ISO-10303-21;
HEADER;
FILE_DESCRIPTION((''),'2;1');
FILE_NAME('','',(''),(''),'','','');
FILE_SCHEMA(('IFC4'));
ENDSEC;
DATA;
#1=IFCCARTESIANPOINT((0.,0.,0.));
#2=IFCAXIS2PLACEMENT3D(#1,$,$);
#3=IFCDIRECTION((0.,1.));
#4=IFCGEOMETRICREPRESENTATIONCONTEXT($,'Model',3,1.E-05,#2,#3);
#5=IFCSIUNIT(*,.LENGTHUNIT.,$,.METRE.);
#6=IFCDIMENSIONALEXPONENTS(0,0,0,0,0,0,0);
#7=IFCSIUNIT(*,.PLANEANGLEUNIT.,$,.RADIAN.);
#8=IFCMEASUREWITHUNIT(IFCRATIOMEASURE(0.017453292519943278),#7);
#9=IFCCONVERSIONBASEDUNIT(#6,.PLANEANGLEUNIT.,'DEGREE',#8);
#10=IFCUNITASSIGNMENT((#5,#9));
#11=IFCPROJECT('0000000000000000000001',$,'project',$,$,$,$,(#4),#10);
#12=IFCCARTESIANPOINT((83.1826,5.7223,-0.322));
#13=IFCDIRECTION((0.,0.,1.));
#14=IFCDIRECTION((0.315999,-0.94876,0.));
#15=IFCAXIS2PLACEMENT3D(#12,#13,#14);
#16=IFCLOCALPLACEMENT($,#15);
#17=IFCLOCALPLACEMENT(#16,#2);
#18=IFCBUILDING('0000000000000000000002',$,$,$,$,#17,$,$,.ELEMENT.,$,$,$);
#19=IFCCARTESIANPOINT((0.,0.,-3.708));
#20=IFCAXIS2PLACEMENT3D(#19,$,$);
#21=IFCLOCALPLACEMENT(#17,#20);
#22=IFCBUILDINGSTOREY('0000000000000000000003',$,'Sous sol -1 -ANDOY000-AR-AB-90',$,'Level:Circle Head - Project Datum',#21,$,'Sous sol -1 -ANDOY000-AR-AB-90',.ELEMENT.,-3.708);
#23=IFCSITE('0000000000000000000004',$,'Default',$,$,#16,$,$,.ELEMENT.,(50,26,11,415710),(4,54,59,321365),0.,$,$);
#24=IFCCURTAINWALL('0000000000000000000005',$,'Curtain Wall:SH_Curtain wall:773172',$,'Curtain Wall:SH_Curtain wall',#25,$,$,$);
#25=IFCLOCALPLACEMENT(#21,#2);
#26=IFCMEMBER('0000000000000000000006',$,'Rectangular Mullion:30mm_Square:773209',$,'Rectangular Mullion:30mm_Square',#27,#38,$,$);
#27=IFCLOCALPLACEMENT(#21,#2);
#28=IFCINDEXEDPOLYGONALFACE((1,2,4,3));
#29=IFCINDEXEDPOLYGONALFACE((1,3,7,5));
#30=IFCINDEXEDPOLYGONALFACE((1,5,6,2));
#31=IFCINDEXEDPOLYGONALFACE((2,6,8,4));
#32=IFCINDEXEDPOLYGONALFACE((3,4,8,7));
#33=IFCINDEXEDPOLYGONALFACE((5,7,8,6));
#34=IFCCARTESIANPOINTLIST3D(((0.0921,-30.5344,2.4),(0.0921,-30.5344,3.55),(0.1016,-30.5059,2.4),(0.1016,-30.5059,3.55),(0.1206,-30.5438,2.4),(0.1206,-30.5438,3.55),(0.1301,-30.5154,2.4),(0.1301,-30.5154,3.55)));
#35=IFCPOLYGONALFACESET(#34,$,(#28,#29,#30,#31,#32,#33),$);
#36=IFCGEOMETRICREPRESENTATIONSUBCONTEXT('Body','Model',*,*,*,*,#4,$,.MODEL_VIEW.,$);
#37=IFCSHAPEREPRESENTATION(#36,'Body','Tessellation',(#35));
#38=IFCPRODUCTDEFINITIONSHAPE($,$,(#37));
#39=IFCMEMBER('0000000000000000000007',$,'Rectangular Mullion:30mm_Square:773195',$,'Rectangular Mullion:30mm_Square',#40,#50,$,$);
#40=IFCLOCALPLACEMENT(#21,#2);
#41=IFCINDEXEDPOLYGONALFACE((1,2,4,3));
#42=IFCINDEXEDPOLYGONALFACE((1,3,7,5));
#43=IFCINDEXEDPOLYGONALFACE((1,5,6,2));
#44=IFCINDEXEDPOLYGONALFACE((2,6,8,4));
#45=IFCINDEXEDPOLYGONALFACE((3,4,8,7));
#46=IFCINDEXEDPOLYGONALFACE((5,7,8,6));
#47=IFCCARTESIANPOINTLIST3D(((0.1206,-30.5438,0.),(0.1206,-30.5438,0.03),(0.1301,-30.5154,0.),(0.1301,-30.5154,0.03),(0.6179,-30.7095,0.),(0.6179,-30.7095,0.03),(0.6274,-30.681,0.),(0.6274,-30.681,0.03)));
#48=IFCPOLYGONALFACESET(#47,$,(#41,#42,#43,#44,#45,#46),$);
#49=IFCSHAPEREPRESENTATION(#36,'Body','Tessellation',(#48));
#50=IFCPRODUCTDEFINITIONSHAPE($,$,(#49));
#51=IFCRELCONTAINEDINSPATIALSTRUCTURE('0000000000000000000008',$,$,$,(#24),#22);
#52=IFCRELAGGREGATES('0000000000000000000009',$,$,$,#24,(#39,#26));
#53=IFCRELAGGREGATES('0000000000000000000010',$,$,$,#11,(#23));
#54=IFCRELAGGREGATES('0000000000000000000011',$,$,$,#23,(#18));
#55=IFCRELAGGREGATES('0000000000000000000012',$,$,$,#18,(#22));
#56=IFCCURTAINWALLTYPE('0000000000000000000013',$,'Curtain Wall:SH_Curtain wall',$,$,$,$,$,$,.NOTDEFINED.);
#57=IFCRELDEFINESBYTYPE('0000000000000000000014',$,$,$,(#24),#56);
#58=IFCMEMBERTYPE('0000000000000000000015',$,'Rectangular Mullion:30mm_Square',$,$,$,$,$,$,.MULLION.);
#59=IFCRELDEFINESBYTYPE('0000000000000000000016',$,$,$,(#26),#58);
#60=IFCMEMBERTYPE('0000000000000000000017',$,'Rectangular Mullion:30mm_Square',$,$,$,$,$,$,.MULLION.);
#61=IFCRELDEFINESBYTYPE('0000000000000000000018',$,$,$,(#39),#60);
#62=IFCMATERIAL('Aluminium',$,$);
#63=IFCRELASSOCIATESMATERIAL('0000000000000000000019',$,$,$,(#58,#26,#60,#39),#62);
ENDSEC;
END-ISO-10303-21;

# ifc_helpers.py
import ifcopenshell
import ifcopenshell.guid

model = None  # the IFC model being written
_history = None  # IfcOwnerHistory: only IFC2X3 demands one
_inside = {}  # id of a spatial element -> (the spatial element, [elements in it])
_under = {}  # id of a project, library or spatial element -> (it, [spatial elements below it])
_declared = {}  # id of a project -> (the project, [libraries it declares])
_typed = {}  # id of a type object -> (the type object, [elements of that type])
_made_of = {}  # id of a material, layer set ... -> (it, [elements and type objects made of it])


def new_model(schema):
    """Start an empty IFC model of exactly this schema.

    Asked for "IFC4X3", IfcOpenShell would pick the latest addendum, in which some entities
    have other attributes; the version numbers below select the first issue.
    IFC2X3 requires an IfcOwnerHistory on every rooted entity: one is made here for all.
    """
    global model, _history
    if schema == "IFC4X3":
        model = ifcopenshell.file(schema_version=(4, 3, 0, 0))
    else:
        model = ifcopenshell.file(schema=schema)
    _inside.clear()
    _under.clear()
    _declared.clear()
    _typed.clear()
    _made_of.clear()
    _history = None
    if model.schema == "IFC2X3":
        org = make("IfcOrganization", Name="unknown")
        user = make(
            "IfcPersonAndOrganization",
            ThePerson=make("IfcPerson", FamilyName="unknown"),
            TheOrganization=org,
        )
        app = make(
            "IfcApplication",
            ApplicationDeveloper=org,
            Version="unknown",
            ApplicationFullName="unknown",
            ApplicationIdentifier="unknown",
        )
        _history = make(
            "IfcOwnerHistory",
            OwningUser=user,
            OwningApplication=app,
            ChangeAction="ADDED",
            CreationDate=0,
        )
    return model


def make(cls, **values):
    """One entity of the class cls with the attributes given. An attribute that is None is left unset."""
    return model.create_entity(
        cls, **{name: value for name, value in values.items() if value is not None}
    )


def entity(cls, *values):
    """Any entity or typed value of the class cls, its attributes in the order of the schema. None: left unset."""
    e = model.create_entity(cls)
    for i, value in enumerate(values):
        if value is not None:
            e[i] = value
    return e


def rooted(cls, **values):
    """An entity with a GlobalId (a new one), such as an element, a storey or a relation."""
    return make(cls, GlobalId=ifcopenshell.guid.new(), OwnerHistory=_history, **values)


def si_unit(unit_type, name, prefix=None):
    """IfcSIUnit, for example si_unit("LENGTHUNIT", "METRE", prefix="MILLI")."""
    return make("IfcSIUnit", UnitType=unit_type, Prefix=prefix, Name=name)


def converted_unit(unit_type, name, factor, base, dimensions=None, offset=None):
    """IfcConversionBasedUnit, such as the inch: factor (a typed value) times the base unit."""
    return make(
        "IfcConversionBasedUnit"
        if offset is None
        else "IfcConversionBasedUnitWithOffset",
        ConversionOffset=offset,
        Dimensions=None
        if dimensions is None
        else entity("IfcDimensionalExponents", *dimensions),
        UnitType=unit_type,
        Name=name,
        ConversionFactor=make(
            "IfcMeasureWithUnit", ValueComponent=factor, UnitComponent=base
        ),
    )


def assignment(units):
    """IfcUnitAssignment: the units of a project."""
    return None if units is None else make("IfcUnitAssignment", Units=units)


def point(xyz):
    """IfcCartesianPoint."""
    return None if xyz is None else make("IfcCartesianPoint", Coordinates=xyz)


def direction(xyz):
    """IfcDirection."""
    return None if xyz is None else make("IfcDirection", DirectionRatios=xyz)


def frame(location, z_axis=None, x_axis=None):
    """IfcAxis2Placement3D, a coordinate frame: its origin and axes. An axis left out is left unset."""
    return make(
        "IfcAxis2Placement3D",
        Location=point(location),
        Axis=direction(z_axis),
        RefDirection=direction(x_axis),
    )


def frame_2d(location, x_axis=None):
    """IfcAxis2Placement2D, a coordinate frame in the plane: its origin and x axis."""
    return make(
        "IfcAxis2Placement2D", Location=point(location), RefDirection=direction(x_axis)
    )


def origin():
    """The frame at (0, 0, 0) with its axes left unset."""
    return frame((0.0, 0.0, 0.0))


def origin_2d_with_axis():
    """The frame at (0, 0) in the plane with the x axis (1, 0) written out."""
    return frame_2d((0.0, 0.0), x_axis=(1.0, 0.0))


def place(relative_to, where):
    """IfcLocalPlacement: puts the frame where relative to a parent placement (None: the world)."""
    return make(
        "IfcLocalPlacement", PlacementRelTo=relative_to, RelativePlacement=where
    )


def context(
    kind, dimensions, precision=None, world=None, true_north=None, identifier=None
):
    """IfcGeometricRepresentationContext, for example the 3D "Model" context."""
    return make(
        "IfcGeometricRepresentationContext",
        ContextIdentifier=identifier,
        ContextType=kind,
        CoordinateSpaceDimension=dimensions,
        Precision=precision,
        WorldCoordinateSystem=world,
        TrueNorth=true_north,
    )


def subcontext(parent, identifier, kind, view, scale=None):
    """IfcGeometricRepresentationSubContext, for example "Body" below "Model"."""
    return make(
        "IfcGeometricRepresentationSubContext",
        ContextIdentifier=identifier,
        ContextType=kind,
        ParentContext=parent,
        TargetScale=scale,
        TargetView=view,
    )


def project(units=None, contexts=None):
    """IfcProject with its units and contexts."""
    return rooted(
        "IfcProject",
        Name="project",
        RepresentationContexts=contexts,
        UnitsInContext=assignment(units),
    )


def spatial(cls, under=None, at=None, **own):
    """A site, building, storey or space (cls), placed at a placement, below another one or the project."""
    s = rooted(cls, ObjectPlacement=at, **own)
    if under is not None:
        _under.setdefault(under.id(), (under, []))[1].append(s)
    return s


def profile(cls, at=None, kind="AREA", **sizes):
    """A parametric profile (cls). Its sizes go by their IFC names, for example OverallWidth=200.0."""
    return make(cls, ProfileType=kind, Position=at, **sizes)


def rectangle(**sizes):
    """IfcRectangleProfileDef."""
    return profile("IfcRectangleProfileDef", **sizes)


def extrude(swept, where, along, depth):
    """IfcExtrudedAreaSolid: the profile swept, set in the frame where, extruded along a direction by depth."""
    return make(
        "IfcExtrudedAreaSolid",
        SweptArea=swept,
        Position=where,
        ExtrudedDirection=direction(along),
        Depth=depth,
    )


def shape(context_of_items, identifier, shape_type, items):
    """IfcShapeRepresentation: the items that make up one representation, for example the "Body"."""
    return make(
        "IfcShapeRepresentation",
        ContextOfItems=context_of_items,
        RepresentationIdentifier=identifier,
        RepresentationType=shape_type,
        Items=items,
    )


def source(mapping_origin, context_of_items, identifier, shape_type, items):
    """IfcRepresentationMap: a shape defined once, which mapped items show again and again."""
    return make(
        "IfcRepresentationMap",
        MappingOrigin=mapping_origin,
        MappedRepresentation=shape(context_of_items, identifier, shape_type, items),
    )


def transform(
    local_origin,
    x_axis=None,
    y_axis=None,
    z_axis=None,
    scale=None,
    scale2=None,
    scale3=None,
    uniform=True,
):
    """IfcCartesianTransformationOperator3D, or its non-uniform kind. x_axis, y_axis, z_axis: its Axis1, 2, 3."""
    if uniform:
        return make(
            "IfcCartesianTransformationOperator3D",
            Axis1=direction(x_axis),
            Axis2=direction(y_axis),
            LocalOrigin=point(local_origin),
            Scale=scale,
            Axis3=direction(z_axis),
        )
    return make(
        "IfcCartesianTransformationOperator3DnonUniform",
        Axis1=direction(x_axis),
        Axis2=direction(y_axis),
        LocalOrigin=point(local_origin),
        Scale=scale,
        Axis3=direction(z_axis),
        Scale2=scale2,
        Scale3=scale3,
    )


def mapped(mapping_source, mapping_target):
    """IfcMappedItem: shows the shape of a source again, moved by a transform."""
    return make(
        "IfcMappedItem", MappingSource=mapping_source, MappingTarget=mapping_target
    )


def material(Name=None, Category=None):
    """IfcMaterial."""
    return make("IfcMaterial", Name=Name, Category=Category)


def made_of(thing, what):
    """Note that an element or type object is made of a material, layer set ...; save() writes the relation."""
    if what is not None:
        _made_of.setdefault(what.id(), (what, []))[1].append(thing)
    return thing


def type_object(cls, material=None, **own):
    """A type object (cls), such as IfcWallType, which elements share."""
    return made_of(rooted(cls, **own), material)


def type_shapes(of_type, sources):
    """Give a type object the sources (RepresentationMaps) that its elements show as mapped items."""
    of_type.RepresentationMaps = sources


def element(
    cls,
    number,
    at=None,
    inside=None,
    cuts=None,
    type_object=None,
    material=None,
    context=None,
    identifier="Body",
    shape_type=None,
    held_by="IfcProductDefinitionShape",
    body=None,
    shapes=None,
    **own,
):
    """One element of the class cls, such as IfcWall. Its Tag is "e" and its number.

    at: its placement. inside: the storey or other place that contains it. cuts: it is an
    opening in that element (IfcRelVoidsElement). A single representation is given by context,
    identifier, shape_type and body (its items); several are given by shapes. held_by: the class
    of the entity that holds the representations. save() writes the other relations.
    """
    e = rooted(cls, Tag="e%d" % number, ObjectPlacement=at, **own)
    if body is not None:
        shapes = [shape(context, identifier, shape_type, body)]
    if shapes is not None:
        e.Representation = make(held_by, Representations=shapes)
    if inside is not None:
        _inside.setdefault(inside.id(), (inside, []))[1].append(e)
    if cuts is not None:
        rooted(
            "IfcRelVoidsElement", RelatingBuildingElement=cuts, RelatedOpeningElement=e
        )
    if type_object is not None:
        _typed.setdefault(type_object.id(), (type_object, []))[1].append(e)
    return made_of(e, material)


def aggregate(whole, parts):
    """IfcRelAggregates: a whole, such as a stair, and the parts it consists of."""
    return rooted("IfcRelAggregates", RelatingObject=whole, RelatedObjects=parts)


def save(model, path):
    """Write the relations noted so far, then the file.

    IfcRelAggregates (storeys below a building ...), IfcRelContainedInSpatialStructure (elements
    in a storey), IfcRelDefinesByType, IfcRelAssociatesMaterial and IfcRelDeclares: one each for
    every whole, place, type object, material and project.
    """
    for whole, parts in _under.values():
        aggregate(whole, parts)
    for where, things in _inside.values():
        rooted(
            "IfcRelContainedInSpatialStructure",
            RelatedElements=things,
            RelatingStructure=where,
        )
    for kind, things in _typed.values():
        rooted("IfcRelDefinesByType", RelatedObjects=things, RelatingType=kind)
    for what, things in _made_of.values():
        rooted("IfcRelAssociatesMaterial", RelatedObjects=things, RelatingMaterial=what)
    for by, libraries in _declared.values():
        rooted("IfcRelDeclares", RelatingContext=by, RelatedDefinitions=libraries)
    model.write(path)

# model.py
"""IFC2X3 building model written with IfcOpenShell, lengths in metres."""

from ifc_helpers import new_model, entity, si_unit, converted_unit, direction, frame, origin, origin_2d_with_axis, place, context, subcontext, project, spatial, rectangle, extrude, source, transform, mapped, material, type_object, type_shapes, element, aggregate, save


model = new_model("IFC2X3")

# Units and contexts
model_context = context("Model", 3, precision=1e-05, world=origin(), true_north=direction((0.0, 1.0)))
body_context = subcontext(model_context, "Body", "Model", "MODEL_VIEW")
ifc_project = project(units=[si_unit("LENGTHUNIT", "METRE"), converted_unit("PLANEANGLEUNIT", "DEGREE", entity("IfcRatioMeasure", 0.017453292519943278), si_unit("PLANEANGLEUNIT", "RADIAN"), dimensions=[0, 0, 0, 0, 0, 0, 0])], contexts=[model_context])

# Site, building, storey
site_placement = place(None, frame((83.1826, 5.7223, -0.322), z_axis=(0.0, 0.0, 1.0), x_axis=(0.315999, -0.94876, 0.0)))
site = spatial("IfcSite", under=ifc_project, at=site_placement, Name="Default", CompositionType="ELEMENT", RefLatitude=(50, 26, 11, 415710), RefLongitude=(4, 54, 59, 321365), RefElevation=0.0)
building_placement = place(site_placement, origin())
building = spatial("IfcBuilding", under=site, at=building_placement, CompositionType="ELEMENT")
storey_placement = place(building_placement, frame((0.0, 0.0, -3.708)))
storey = spatial("IfcBuildingStorey", under=building, at=storey_placement, Name="Sous sol -1 -ANDOY000-AR-AB-90", ObjectType="Level:Circle Head - Project Datum", LongName="Sous sol -1 -ANDOY000-AR-AB-90", CompositionType="ELEMENT", Elevation=-3.708)

# Curtain wall, members
curtain_wall_type = type_object("IfcCurtainWallType", Name="Curtain Wall:SH_Curtain wall", PredefinedType="NOTDEFINED")
curtain_wall_placement = place(storey_placement, frame((0.0, 0.0, 3.708)))
curtain_wall = element("IfcCurtainWall", 1, at=curtain_wall_placement, inside=storey, type_object=curtain_wall_type, Name="Curtain Wall:SH_Curtain wall:773172", ObjectType="Curtain Wall:SH_Curtain wall")
ifc_material_1 = material(Name="Aluminium")
member_type_1 = type_object("IfcMemberType", Name="Rectangular Mullion:30mm_Square", PredefinedType="MULLION", material=ifc_material_1)
shared_shape_1 = source(origin(), body_context, "Body", "SweptSolid", [
    extrude(rectangle(XDim=0.03, YDim=0.03, at=origin_2d_with_axis()), frame((0.0, 0.0, -1.15), z_axis=(0.0, 0.0, 1.0), x_axis=(0.0, -1.0, 0.0)), (0.0, 0.0, 1.0), 1.15),
])
type_shapes(member_type_1, [shared_shape_1])
member_1_placement = place(curtain_wall_placement, frame((0.1111, -30.5249, -1.308), z_axis=(0.0, 0.0, -1.0), x_axis=(0.948759, -0.316, 0.0)))
member_1 = element("IfcMember", 2, at=member_1_placement, type_object=member_type_1, material=ifc_material_1, Name="Rectangular Mullion:30mm_Square:773209", ObjectType="Rectangular Mullion:30mm_Square", context=body_context, shape_type="MappedRepresentation", body=[
    mapped(shared_shape_1, transform((0.0, 0.0, 0.0), scale=1.0)),
])
member_type_2 = type_object("IfcMemberType", Name="Rectangular Mullion:30mm_Square", PredefinedType="MULLION", material=ifc_material_1)
shared_shape_2 = source(origin(), body_context, "Body", "SweptSolid", [
    extrude(rectangle(XDim=0.03, YDim=0.03, at=origin_2d_with_axis()), frame((-0.015, 0.0, -0.5242), z_axis=(0.0, 0.0, 1.0), x_axis=(0.0, -1.0, 0.0)), (0.0, 0.0, 1.0), 0.5242),
])
type_shapes(member_type_2, [shared_shape_2])
member_2_placement = place(curtain_wall_placement, frame((0.1253, -30.5296, -3.708), z_axis=(-0.948759, 0.316, 0.0), x_axis=(0.0, 0.0, -1.0)))
member_2 = element("IfcMember", 3, at=member_2_placement, type_object=member_type_2, material=ifc_material_1, Name="Rectangular Mullion:30mm_Square:773195", ObjectType="Rectangular Mullion:30mm_Square", context=body_context, shape_type="MappedRepresentation", body=[
    mapped(shared_shape_2, transform((0.0, 0.0, 0.0), scale=1.0)),
])
aggregate(curtain_wall, [member_2, member_1])

save(model, "model.ifc")
